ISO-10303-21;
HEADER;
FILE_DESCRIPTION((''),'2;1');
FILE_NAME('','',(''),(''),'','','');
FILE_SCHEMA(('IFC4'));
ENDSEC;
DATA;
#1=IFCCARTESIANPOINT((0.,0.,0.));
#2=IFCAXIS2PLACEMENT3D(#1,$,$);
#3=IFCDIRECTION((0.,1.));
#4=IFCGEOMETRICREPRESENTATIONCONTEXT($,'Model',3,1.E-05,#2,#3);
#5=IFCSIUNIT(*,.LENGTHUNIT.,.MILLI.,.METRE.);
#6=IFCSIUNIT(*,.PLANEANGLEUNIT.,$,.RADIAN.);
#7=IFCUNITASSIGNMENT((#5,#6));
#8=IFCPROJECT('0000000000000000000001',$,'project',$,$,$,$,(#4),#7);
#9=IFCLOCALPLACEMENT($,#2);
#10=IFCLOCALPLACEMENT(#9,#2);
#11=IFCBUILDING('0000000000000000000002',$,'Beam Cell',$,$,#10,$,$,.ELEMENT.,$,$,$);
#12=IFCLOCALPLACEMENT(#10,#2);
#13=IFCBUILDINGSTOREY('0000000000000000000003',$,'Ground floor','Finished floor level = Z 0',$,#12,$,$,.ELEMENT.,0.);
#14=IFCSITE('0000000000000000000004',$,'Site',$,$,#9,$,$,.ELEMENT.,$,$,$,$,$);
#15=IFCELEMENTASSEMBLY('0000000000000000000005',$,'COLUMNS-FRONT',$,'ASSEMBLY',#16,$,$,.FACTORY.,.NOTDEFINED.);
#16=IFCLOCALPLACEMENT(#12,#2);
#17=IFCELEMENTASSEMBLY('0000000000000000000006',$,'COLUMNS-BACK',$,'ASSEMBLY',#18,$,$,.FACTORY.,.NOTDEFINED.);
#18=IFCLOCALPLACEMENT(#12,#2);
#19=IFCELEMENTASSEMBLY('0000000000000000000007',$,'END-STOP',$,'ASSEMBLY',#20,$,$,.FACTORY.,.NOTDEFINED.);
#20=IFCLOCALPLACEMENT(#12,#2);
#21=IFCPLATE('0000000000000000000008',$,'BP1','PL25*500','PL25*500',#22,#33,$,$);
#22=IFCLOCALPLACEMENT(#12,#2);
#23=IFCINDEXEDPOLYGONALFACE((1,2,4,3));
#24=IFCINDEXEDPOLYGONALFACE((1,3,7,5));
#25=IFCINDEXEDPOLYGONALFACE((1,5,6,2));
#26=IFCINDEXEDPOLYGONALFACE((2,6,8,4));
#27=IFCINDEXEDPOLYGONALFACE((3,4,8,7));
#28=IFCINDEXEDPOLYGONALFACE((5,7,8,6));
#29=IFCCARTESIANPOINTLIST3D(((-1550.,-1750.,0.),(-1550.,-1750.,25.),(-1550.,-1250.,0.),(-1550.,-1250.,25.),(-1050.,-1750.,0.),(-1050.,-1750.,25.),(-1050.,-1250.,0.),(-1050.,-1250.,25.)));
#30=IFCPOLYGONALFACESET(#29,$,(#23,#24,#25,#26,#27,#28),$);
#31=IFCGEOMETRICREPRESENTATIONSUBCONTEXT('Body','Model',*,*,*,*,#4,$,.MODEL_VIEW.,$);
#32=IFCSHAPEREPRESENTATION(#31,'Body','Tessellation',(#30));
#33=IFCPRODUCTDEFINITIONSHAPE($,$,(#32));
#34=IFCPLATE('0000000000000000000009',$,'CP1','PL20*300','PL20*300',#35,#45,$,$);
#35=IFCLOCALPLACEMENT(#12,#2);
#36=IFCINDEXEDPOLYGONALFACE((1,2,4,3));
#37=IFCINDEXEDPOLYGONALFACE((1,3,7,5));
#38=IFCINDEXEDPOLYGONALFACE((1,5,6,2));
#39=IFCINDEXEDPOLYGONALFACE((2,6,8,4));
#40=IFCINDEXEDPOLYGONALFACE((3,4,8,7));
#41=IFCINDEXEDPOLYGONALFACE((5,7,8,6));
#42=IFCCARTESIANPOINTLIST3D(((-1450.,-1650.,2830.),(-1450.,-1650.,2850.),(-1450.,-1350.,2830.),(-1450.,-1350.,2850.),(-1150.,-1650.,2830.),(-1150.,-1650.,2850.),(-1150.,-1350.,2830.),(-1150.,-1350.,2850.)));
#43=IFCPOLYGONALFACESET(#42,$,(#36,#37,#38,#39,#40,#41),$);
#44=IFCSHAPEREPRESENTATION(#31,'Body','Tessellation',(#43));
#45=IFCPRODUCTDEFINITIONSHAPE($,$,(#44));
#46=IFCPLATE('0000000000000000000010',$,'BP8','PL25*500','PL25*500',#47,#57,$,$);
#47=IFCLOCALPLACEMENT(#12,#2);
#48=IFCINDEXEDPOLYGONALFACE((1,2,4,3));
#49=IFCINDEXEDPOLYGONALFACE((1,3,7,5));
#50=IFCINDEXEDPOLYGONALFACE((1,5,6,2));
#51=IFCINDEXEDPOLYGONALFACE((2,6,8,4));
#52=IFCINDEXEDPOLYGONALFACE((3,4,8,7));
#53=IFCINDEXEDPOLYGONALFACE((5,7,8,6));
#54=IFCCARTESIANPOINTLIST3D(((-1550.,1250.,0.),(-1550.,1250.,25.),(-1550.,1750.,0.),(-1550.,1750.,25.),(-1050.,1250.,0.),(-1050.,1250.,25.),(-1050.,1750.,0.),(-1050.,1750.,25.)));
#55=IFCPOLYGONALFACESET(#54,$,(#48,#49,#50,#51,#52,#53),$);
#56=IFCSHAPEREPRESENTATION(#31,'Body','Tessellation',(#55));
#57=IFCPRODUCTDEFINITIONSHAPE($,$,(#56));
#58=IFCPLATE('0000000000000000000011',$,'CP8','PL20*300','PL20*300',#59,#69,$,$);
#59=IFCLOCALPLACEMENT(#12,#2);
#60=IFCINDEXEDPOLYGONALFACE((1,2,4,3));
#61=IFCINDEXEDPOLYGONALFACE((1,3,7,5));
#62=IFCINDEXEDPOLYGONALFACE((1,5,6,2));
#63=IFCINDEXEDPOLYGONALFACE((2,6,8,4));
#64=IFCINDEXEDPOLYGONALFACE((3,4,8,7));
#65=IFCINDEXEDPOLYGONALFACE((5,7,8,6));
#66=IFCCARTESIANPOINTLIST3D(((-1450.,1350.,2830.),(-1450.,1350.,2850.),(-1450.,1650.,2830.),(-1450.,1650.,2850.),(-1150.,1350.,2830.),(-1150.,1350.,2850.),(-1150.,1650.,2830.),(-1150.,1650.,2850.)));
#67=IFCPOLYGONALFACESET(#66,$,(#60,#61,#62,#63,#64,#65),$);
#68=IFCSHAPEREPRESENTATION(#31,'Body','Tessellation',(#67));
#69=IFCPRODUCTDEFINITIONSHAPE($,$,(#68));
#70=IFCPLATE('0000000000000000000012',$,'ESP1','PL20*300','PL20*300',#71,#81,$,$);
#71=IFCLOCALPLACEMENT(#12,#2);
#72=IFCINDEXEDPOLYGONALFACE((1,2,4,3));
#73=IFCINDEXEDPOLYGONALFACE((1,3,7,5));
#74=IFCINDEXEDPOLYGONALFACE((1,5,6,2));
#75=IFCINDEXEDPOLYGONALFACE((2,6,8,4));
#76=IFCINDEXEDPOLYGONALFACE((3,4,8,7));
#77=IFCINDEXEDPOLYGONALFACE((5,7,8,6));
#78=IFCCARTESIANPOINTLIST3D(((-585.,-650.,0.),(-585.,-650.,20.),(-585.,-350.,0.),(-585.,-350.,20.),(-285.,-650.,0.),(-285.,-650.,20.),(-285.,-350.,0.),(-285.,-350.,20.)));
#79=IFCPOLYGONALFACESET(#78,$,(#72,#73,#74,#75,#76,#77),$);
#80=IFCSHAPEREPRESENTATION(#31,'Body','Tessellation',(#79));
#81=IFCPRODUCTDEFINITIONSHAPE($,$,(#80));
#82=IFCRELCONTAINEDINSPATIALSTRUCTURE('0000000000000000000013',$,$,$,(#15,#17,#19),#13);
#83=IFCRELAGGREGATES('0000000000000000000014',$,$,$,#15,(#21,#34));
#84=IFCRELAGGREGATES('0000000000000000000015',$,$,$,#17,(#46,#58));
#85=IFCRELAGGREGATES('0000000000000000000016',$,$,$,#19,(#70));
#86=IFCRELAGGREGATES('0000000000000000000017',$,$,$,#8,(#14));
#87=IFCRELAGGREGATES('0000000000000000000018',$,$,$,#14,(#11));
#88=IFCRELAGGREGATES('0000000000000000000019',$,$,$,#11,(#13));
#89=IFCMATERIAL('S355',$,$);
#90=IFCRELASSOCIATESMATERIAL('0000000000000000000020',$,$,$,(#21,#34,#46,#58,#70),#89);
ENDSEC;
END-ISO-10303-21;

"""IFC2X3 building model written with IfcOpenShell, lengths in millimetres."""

from ifc_helpers import new_model, si_unit, direction, frame, origin, origin_2d, place, context, subcontext, project, spatial, rectangle, extrude, material, element, aggregate, save


model = new_model("IFC2X3")

# Units and contexts
model_context = context("Model", 3, precision=1e-05, world=origin(), true_north=direction((0.0, 1.0)))
body_context = subcontext(model_context, "Body", "Model", "MODEL_VIEW")
ifc_project = project(units=[si_unit("LENGTHUNIT", "METRE", prefix="MILLI"), si_unit("PLANEANGLEUNIT", "RADIAN")], contexts=[model_context])

# Site, building, storey
site_placement = place(None, origin())
site = spatial("IfcSite", under=ifc_project, at=site_placement, Name="Site", CompositionType="ELEMENT")
building_placement = place(site_placement, origin())
building = spatial("IfcBuilding", under=site, at=building_placement, Name="Beam Cell", CompositionType="ELEMENT")
storey_placement = place(building_placement, origin())
storey = spatial("IfcBuildingStorey", under=building, at=storey_placement, Name="Ground floor", Description="Finished floor level = Z 0", CompositionType="ELEMENT", Elevation=0.0)

# Element assemblies
assembly_1_placement = place(storey_placement, origin())
assembly_1 = element("IfcElementAssembly", 1, at=assembly_1_placement, inside=storey, Name="COLUMNS-FRONT", ObjectType="ASSEMBLY", AssemblyPlace="FACTORY", PredefinedType="NOTDEFINED")
ifc_material = material(Name="S355")
assembly_2_placement = place(storey_placement, origin())
assembly_2 = element("IfcElementAssembly", 2, at=assembly_2_placement, inside=storey, Name="COLUMNS-BACK", ObjectType="ASSEMBLY", AssemblyPlace="FACTORY", PredefinedType="NOTDEFINED")

# Element assembly
assembly_3_placement = place(storey_placement, origin())
assembly_3 = element("IfcElementAssembly", 3, at=assembly_3_placement, inside=storey, Name="END-STOP", ObjectType="ASSEMBLY", AssemblyPlace="FACTORY", PredefinedType="NOTDEFINED")

# Plates
plate_1_placement = place(storey_placement, frame((-1300.0, -1500.0, 0.0), z_axis=(0.0, 0.0, 1.0), x_axis=(1.0, 0.0, 0.0)))
plate_1 = element("IfcPlate", 4, at=plate_1_placement, material=ifc_material, Name="BP1", Description="PL25*500", ObjectType="PL25*500", context=body_context, shape_type="SweptSolid", body=[
    extrude(rectangle(XDim=500.0, YDim=500.0, at=origin_2d()), origin(), (0.0, 0.0, 1.0), 25.0),
])
plate_2_placement = place(storey_placement, frame((-1300.0, -1500.0, 2830.0), z_axis=(0.0, 0.0, 1.0), x_axis=(1.0, 0.0, 0.0)))
plate_2 = element("IfcPlate", 5, at=plate_2_placement, material=ifc_material, Name="CP1", Description="PL20*300", ObjectType="PL20*300", context=body_context, shape_type="SweptSolid", body=[
    extrude(rectangle(XDim=300.0, YDim=300.0, at=origin_2d()), origin(), (0.0, 0.0, 1.0), 20.0),
])
aggregate(assembly_1, [plate_1, plate_2])
plate_3_placement = place(storey_placement, frame((-1300.0, 1500.0, 0.0), z_axis=(0.0, 0.0, 1.0), x_axis=(1.0, 0.0, 0.0)))
plate_3 = element("IfcPlate", 6, at=plate_3_placement, material=ifc_material, Name="BP8", Description="PL25*500", ObjectType="PL25*500", context=body_context, shape_type="SweptSolid", body=[
    extrude(rectangle(XDim=500.0, YDim=500.0, at=origin_2d()), origin(), (0.0, 0.0, 1.0), 25.0),
])
plate_4_placement = place(storey_placement, frame((-1300.0, 1500.0, 2830.0), z_axis=(0.0, 0.0, 1.0), x_axis=(1.0, 0.0, 0.0)))
plate_4 = element("IfcPlate", 7, at=plate_4_placement, material=ifc_material, Name="CP8", Description="PL20*300", ObjectType="PL20*300", context=body_context, shape_type="SweptSolid", body=[
    extrude(rectangle(XDim=300.0, YDim=300.0, at=origin_2d()), origin(), (0.0, 0.0, 1.0), 20.0),
])
aggregate(assembly_2, [plate_3, plate_4])
plate_5_placement = place(storey_placement, frame((-435.0, -500.0, 0.0), z_axis=(0.0, 0.0, 1.0), x_axis=(1.0, 0.0, 0.0)))
plate_5 = element("IfcPlate", 8, at=plate_5_placement, material=ifc_material, Name="ESP1", Description="PL20*300", ObjectType="PL20*300", context=body_context, shape_type="SweptSolid", body=[
    extrude(rectangle(XDim=300.0, YDim=300.0, at=origin_2d()), origin(), (0.0, 0.0, 1.0), 20.0),
])
aggregate(assembly_3, [plate_5])

save(model, "model.ifc")
